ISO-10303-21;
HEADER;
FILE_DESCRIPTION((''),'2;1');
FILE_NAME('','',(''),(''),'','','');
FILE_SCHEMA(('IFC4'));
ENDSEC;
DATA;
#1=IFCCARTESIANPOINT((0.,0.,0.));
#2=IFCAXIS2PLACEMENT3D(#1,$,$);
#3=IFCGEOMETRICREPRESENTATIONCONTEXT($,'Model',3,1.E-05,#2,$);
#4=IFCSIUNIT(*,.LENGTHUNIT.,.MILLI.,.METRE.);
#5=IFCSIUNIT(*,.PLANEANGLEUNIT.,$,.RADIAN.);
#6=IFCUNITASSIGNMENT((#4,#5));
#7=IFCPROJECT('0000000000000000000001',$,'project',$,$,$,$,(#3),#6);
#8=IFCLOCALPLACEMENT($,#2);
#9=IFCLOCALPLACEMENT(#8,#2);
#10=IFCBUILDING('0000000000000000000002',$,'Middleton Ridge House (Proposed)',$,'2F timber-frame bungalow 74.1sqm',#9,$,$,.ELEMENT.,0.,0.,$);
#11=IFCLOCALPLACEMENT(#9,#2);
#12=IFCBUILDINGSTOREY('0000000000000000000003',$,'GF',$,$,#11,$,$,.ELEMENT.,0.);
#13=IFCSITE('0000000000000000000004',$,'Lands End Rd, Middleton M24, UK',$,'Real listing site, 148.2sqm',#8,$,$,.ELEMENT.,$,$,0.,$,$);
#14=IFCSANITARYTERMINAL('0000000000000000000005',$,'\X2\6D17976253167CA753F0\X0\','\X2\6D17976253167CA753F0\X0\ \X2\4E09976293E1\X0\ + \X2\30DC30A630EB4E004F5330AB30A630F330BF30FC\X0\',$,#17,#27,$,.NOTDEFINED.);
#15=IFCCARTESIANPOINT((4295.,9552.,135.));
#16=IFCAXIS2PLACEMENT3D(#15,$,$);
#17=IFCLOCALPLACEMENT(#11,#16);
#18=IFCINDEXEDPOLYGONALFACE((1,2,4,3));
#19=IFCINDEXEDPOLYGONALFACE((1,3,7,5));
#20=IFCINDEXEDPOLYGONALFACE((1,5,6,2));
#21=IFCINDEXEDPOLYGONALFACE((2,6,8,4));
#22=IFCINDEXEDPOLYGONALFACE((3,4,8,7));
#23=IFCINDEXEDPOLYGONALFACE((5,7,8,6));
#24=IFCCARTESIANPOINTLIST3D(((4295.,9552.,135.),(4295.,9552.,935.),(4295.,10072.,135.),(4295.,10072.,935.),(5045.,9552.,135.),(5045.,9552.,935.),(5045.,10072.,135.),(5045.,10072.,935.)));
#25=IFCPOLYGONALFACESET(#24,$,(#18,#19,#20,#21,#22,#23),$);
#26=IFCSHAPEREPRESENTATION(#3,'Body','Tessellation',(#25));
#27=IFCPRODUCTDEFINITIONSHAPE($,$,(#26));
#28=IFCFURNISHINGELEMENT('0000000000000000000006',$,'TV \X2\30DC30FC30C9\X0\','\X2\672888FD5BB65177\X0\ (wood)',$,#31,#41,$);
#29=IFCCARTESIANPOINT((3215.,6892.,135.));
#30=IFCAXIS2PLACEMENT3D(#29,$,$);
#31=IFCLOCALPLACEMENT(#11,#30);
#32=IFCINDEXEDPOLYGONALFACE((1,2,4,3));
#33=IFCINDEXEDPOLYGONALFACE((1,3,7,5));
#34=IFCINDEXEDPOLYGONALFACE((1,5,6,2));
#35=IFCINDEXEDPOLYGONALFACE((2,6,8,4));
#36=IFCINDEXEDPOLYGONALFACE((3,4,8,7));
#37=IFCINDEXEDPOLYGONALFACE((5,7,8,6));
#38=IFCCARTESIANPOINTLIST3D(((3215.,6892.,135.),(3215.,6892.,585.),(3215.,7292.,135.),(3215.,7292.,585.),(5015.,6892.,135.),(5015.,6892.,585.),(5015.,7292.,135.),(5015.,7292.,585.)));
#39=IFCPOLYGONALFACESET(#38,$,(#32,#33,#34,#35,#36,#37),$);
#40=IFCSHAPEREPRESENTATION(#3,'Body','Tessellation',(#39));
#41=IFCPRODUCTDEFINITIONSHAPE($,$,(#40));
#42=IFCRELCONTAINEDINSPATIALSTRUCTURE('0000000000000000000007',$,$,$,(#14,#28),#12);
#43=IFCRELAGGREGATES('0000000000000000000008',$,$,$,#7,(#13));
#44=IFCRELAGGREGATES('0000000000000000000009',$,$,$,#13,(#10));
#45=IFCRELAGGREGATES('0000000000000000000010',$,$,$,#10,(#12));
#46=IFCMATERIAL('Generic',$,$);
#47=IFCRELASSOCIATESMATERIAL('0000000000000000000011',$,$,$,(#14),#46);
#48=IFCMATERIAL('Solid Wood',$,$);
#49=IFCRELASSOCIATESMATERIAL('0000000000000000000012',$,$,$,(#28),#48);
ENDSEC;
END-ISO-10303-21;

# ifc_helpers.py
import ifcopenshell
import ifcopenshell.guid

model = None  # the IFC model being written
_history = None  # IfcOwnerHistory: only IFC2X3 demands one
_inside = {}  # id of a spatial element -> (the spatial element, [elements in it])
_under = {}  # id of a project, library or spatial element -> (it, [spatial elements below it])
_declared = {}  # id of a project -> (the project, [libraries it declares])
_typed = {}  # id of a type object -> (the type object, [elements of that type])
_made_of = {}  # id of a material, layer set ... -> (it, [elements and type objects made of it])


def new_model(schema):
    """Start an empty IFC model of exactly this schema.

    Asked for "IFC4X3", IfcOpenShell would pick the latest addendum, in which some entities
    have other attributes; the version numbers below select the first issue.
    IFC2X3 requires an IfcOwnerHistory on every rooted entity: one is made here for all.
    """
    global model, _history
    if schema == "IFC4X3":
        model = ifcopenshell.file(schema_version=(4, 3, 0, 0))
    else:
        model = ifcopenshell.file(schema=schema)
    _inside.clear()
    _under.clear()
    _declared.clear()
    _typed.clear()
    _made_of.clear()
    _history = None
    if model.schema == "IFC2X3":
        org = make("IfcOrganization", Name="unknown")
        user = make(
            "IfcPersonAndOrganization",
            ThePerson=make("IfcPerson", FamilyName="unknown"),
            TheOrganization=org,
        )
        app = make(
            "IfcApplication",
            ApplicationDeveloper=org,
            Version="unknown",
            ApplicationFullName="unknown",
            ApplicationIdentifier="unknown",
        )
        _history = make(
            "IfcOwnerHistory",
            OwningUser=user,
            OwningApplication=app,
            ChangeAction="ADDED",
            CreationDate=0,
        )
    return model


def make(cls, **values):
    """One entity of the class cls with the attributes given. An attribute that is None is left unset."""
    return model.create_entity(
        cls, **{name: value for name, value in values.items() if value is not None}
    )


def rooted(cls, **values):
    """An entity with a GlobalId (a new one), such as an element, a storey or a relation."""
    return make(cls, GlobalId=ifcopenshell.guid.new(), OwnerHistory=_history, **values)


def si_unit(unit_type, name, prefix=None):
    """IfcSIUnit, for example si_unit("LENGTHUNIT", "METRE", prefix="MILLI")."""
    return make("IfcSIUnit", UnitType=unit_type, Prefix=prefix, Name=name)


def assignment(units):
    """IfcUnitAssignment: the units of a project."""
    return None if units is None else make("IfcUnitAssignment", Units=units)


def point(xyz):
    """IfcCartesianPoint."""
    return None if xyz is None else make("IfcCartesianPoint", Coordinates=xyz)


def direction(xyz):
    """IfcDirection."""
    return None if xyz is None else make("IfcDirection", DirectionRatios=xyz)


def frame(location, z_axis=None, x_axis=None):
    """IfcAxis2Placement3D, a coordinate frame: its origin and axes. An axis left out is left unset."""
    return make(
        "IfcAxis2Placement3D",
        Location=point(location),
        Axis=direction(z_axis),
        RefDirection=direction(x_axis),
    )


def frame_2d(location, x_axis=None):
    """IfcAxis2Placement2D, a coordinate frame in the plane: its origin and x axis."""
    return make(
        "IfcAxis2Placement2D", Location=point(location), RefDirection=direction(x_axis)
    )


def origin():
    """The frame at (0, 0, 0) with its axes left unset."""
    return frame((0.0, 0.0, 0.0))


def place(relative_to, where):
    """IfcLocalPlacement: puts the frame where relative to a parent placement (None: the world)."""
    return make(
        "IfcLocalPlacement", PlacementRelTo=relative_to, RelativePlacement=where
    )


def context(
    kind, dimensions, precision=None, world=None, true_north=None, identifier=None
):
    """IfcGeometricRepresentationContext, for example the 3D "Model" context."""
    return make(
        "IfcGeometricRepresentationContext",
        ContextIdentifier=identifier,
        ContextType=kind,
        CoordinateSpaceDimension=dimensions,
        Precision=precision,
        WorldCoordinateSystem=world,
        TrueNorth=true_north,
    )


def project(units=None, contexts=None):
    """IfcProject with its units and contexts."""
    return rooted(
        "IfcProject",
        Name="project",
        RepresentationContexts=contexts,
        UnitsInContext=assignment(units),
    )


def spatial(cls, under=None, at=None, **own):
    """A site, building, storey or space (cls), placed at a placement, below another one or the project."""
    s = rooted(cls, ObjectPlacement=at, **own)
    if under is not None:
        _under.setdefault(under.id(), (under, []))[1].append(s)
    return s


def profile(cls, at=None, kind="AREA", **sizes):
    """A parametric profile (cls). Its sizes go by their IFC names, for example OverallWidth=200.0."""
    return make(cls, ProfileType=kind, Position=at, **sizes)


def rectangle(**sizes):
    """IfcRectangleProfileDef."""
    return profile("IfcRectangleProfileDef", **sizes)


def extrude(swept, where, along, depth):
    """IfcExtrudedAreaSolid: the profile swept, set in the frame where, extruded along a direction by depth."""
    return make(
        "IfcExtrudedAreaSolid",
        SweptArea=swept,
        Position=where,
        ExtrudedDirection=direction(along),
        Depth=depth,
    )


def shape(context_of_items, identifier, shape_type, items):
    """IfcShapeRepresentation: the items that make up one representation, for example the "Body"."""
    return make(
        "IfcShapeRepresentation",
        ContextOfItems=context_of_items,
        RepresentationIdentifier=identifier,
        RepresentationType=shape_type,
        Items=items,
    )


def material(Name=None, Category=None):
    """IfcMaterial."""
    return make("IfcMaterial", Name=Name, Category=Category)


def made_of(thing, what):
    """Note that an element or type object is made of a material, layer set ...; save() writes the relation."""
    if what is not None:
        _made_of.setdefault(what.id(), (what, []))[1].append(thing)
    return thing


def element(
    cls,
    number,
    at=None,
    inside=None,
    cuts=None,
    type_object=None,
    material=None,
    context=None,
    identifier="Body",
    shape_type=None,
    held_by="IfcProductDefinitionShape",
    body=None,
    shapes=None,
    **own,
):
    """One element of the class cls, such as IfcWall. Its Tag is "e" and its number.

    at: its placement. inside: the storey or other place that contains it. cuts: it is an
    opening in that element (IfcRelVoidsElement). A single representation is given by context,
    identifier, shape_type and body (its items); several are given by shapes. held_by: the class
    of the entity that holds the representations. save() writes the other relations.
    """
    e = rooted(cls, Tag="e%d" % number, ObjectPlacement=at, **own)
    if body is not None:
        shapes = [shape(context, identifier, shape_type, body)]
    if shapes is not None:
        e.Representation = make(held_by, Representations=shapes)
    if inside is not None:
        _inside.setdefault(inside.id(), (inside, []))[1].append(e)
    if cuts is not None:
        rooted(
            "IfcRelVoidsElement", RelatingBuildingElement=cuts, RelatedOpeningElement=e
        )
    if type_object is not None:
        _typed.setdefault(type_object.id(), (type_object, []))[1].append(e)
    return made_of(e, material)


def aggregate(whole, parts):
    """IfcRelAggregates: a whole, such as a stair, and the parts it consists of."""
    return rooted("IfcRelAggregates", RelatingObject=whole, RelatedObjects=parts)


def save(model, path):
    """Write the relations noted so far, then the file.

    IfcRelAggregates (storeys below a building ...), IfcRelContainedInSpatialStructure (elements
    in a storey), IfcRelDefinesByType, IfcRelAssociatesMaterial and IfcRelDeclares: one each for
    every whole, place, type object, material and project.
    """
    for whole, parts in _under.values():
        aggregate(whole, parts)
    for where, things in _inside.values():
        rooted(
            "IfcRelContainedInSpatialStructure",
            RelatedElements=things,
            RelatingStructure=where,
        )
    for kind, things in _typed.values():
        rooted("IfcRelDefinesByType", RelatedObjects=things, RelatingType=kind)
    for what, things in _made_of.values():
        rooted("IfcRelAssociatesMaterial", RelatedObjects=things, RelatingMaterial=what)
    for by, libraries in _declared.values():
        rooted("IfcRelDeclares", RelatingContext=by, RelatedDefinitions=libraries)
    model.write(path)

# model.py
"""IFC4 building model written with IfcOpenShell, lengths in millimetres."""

from ifc_helpers import new_model, si_unit, frame, frame_2d, origin, place, context, project, spatial, rectangle, extrude, material, element, save


model = new_model("IFC4")

# Units and contexts
model_context = context("Model", 3, precision=1e-05, world=origin())
ifc_project = project(units=[si_unit("LENGTHUNIT", "METRE", prefix="MILLI"), si_unit("PLANEANGLEUNIT", "RADIAN")], contexts=[model_context])

# Site, building, storey
site_placement = place(None, origin())
site = spatial("IfcSite", under=ifc_project, at=site_placement, Name="Lands End Rd, Middleton M24, UK", ObjectType="Real listing site, 148.2sqm", CompositionType="ELEMENT", RefElevation=0.0)
building_placement = place(site_placement, origin())
building = spatial("IfcBuilding", under=site, at=building_placement, Name="Middleton Ridge House (Proposed)", ObjectType="2F timber-frame bungalow 74.1sqm", CompositionType="ELEMENT", ElevationOfRefHeight=0.0, ElevationOfTerrain=0.0)
storey_placement = place(building_placement, origin())
storey = spatial("IfcBuildingStorey", under=building, at=storey_placement, Name="GF", CompositionType="ELEMENT", Elevation=0.0)

# Shared definitions
ifc_material_1 = material(Name="Solid Wood")

# Shared definitions
ifc_material_2 = material(Name="Generic")

# Sanitary terminal
sanitary_terminal_1_placement = place(storey_placement, frame((4295.0, 9552.0, 135.0)))
element("IfcSanitaryTerminal", 1, at=sanitary_terminal_1_placement, inside=storey, material=ifc_material_2, Name="洗面化粧台", Description="洗面化粧台 三面鏡 + ボウル一体カウンター", PredefinedType="NOTDEFINED", context=model_context, shape_type="SweptSolid", body=[
    extrude(rectangle(XDim=750.0, YDim=520.0, at=frame_2d((375.0, 260.0))), frame((4295.0, 9552.0, 135.0)), (0.0, 0.0, 1.0), 800.0),
])

# Furnishing element
furnishing_placement = place(storey_placement, frame((3215.0, 6892.0, 135.0)))
element("IfcFurnishingElement", 2, at=furnishing_placement, inside=storey, material=ifc_material_1, Name="TV ボード", Description="木製家具 (wood)", context=model_context, shape_type="SweptSolid", body=[
    extrude(rectangle(XDim=1800.0, YDim=400.0, at=frame_2d((900.0, 200.0))), frame((3215.0, 6892.0, 135.0)), (0.0, 0.0, 1.0), 450.0),
])

save(model, "model.ifc")
